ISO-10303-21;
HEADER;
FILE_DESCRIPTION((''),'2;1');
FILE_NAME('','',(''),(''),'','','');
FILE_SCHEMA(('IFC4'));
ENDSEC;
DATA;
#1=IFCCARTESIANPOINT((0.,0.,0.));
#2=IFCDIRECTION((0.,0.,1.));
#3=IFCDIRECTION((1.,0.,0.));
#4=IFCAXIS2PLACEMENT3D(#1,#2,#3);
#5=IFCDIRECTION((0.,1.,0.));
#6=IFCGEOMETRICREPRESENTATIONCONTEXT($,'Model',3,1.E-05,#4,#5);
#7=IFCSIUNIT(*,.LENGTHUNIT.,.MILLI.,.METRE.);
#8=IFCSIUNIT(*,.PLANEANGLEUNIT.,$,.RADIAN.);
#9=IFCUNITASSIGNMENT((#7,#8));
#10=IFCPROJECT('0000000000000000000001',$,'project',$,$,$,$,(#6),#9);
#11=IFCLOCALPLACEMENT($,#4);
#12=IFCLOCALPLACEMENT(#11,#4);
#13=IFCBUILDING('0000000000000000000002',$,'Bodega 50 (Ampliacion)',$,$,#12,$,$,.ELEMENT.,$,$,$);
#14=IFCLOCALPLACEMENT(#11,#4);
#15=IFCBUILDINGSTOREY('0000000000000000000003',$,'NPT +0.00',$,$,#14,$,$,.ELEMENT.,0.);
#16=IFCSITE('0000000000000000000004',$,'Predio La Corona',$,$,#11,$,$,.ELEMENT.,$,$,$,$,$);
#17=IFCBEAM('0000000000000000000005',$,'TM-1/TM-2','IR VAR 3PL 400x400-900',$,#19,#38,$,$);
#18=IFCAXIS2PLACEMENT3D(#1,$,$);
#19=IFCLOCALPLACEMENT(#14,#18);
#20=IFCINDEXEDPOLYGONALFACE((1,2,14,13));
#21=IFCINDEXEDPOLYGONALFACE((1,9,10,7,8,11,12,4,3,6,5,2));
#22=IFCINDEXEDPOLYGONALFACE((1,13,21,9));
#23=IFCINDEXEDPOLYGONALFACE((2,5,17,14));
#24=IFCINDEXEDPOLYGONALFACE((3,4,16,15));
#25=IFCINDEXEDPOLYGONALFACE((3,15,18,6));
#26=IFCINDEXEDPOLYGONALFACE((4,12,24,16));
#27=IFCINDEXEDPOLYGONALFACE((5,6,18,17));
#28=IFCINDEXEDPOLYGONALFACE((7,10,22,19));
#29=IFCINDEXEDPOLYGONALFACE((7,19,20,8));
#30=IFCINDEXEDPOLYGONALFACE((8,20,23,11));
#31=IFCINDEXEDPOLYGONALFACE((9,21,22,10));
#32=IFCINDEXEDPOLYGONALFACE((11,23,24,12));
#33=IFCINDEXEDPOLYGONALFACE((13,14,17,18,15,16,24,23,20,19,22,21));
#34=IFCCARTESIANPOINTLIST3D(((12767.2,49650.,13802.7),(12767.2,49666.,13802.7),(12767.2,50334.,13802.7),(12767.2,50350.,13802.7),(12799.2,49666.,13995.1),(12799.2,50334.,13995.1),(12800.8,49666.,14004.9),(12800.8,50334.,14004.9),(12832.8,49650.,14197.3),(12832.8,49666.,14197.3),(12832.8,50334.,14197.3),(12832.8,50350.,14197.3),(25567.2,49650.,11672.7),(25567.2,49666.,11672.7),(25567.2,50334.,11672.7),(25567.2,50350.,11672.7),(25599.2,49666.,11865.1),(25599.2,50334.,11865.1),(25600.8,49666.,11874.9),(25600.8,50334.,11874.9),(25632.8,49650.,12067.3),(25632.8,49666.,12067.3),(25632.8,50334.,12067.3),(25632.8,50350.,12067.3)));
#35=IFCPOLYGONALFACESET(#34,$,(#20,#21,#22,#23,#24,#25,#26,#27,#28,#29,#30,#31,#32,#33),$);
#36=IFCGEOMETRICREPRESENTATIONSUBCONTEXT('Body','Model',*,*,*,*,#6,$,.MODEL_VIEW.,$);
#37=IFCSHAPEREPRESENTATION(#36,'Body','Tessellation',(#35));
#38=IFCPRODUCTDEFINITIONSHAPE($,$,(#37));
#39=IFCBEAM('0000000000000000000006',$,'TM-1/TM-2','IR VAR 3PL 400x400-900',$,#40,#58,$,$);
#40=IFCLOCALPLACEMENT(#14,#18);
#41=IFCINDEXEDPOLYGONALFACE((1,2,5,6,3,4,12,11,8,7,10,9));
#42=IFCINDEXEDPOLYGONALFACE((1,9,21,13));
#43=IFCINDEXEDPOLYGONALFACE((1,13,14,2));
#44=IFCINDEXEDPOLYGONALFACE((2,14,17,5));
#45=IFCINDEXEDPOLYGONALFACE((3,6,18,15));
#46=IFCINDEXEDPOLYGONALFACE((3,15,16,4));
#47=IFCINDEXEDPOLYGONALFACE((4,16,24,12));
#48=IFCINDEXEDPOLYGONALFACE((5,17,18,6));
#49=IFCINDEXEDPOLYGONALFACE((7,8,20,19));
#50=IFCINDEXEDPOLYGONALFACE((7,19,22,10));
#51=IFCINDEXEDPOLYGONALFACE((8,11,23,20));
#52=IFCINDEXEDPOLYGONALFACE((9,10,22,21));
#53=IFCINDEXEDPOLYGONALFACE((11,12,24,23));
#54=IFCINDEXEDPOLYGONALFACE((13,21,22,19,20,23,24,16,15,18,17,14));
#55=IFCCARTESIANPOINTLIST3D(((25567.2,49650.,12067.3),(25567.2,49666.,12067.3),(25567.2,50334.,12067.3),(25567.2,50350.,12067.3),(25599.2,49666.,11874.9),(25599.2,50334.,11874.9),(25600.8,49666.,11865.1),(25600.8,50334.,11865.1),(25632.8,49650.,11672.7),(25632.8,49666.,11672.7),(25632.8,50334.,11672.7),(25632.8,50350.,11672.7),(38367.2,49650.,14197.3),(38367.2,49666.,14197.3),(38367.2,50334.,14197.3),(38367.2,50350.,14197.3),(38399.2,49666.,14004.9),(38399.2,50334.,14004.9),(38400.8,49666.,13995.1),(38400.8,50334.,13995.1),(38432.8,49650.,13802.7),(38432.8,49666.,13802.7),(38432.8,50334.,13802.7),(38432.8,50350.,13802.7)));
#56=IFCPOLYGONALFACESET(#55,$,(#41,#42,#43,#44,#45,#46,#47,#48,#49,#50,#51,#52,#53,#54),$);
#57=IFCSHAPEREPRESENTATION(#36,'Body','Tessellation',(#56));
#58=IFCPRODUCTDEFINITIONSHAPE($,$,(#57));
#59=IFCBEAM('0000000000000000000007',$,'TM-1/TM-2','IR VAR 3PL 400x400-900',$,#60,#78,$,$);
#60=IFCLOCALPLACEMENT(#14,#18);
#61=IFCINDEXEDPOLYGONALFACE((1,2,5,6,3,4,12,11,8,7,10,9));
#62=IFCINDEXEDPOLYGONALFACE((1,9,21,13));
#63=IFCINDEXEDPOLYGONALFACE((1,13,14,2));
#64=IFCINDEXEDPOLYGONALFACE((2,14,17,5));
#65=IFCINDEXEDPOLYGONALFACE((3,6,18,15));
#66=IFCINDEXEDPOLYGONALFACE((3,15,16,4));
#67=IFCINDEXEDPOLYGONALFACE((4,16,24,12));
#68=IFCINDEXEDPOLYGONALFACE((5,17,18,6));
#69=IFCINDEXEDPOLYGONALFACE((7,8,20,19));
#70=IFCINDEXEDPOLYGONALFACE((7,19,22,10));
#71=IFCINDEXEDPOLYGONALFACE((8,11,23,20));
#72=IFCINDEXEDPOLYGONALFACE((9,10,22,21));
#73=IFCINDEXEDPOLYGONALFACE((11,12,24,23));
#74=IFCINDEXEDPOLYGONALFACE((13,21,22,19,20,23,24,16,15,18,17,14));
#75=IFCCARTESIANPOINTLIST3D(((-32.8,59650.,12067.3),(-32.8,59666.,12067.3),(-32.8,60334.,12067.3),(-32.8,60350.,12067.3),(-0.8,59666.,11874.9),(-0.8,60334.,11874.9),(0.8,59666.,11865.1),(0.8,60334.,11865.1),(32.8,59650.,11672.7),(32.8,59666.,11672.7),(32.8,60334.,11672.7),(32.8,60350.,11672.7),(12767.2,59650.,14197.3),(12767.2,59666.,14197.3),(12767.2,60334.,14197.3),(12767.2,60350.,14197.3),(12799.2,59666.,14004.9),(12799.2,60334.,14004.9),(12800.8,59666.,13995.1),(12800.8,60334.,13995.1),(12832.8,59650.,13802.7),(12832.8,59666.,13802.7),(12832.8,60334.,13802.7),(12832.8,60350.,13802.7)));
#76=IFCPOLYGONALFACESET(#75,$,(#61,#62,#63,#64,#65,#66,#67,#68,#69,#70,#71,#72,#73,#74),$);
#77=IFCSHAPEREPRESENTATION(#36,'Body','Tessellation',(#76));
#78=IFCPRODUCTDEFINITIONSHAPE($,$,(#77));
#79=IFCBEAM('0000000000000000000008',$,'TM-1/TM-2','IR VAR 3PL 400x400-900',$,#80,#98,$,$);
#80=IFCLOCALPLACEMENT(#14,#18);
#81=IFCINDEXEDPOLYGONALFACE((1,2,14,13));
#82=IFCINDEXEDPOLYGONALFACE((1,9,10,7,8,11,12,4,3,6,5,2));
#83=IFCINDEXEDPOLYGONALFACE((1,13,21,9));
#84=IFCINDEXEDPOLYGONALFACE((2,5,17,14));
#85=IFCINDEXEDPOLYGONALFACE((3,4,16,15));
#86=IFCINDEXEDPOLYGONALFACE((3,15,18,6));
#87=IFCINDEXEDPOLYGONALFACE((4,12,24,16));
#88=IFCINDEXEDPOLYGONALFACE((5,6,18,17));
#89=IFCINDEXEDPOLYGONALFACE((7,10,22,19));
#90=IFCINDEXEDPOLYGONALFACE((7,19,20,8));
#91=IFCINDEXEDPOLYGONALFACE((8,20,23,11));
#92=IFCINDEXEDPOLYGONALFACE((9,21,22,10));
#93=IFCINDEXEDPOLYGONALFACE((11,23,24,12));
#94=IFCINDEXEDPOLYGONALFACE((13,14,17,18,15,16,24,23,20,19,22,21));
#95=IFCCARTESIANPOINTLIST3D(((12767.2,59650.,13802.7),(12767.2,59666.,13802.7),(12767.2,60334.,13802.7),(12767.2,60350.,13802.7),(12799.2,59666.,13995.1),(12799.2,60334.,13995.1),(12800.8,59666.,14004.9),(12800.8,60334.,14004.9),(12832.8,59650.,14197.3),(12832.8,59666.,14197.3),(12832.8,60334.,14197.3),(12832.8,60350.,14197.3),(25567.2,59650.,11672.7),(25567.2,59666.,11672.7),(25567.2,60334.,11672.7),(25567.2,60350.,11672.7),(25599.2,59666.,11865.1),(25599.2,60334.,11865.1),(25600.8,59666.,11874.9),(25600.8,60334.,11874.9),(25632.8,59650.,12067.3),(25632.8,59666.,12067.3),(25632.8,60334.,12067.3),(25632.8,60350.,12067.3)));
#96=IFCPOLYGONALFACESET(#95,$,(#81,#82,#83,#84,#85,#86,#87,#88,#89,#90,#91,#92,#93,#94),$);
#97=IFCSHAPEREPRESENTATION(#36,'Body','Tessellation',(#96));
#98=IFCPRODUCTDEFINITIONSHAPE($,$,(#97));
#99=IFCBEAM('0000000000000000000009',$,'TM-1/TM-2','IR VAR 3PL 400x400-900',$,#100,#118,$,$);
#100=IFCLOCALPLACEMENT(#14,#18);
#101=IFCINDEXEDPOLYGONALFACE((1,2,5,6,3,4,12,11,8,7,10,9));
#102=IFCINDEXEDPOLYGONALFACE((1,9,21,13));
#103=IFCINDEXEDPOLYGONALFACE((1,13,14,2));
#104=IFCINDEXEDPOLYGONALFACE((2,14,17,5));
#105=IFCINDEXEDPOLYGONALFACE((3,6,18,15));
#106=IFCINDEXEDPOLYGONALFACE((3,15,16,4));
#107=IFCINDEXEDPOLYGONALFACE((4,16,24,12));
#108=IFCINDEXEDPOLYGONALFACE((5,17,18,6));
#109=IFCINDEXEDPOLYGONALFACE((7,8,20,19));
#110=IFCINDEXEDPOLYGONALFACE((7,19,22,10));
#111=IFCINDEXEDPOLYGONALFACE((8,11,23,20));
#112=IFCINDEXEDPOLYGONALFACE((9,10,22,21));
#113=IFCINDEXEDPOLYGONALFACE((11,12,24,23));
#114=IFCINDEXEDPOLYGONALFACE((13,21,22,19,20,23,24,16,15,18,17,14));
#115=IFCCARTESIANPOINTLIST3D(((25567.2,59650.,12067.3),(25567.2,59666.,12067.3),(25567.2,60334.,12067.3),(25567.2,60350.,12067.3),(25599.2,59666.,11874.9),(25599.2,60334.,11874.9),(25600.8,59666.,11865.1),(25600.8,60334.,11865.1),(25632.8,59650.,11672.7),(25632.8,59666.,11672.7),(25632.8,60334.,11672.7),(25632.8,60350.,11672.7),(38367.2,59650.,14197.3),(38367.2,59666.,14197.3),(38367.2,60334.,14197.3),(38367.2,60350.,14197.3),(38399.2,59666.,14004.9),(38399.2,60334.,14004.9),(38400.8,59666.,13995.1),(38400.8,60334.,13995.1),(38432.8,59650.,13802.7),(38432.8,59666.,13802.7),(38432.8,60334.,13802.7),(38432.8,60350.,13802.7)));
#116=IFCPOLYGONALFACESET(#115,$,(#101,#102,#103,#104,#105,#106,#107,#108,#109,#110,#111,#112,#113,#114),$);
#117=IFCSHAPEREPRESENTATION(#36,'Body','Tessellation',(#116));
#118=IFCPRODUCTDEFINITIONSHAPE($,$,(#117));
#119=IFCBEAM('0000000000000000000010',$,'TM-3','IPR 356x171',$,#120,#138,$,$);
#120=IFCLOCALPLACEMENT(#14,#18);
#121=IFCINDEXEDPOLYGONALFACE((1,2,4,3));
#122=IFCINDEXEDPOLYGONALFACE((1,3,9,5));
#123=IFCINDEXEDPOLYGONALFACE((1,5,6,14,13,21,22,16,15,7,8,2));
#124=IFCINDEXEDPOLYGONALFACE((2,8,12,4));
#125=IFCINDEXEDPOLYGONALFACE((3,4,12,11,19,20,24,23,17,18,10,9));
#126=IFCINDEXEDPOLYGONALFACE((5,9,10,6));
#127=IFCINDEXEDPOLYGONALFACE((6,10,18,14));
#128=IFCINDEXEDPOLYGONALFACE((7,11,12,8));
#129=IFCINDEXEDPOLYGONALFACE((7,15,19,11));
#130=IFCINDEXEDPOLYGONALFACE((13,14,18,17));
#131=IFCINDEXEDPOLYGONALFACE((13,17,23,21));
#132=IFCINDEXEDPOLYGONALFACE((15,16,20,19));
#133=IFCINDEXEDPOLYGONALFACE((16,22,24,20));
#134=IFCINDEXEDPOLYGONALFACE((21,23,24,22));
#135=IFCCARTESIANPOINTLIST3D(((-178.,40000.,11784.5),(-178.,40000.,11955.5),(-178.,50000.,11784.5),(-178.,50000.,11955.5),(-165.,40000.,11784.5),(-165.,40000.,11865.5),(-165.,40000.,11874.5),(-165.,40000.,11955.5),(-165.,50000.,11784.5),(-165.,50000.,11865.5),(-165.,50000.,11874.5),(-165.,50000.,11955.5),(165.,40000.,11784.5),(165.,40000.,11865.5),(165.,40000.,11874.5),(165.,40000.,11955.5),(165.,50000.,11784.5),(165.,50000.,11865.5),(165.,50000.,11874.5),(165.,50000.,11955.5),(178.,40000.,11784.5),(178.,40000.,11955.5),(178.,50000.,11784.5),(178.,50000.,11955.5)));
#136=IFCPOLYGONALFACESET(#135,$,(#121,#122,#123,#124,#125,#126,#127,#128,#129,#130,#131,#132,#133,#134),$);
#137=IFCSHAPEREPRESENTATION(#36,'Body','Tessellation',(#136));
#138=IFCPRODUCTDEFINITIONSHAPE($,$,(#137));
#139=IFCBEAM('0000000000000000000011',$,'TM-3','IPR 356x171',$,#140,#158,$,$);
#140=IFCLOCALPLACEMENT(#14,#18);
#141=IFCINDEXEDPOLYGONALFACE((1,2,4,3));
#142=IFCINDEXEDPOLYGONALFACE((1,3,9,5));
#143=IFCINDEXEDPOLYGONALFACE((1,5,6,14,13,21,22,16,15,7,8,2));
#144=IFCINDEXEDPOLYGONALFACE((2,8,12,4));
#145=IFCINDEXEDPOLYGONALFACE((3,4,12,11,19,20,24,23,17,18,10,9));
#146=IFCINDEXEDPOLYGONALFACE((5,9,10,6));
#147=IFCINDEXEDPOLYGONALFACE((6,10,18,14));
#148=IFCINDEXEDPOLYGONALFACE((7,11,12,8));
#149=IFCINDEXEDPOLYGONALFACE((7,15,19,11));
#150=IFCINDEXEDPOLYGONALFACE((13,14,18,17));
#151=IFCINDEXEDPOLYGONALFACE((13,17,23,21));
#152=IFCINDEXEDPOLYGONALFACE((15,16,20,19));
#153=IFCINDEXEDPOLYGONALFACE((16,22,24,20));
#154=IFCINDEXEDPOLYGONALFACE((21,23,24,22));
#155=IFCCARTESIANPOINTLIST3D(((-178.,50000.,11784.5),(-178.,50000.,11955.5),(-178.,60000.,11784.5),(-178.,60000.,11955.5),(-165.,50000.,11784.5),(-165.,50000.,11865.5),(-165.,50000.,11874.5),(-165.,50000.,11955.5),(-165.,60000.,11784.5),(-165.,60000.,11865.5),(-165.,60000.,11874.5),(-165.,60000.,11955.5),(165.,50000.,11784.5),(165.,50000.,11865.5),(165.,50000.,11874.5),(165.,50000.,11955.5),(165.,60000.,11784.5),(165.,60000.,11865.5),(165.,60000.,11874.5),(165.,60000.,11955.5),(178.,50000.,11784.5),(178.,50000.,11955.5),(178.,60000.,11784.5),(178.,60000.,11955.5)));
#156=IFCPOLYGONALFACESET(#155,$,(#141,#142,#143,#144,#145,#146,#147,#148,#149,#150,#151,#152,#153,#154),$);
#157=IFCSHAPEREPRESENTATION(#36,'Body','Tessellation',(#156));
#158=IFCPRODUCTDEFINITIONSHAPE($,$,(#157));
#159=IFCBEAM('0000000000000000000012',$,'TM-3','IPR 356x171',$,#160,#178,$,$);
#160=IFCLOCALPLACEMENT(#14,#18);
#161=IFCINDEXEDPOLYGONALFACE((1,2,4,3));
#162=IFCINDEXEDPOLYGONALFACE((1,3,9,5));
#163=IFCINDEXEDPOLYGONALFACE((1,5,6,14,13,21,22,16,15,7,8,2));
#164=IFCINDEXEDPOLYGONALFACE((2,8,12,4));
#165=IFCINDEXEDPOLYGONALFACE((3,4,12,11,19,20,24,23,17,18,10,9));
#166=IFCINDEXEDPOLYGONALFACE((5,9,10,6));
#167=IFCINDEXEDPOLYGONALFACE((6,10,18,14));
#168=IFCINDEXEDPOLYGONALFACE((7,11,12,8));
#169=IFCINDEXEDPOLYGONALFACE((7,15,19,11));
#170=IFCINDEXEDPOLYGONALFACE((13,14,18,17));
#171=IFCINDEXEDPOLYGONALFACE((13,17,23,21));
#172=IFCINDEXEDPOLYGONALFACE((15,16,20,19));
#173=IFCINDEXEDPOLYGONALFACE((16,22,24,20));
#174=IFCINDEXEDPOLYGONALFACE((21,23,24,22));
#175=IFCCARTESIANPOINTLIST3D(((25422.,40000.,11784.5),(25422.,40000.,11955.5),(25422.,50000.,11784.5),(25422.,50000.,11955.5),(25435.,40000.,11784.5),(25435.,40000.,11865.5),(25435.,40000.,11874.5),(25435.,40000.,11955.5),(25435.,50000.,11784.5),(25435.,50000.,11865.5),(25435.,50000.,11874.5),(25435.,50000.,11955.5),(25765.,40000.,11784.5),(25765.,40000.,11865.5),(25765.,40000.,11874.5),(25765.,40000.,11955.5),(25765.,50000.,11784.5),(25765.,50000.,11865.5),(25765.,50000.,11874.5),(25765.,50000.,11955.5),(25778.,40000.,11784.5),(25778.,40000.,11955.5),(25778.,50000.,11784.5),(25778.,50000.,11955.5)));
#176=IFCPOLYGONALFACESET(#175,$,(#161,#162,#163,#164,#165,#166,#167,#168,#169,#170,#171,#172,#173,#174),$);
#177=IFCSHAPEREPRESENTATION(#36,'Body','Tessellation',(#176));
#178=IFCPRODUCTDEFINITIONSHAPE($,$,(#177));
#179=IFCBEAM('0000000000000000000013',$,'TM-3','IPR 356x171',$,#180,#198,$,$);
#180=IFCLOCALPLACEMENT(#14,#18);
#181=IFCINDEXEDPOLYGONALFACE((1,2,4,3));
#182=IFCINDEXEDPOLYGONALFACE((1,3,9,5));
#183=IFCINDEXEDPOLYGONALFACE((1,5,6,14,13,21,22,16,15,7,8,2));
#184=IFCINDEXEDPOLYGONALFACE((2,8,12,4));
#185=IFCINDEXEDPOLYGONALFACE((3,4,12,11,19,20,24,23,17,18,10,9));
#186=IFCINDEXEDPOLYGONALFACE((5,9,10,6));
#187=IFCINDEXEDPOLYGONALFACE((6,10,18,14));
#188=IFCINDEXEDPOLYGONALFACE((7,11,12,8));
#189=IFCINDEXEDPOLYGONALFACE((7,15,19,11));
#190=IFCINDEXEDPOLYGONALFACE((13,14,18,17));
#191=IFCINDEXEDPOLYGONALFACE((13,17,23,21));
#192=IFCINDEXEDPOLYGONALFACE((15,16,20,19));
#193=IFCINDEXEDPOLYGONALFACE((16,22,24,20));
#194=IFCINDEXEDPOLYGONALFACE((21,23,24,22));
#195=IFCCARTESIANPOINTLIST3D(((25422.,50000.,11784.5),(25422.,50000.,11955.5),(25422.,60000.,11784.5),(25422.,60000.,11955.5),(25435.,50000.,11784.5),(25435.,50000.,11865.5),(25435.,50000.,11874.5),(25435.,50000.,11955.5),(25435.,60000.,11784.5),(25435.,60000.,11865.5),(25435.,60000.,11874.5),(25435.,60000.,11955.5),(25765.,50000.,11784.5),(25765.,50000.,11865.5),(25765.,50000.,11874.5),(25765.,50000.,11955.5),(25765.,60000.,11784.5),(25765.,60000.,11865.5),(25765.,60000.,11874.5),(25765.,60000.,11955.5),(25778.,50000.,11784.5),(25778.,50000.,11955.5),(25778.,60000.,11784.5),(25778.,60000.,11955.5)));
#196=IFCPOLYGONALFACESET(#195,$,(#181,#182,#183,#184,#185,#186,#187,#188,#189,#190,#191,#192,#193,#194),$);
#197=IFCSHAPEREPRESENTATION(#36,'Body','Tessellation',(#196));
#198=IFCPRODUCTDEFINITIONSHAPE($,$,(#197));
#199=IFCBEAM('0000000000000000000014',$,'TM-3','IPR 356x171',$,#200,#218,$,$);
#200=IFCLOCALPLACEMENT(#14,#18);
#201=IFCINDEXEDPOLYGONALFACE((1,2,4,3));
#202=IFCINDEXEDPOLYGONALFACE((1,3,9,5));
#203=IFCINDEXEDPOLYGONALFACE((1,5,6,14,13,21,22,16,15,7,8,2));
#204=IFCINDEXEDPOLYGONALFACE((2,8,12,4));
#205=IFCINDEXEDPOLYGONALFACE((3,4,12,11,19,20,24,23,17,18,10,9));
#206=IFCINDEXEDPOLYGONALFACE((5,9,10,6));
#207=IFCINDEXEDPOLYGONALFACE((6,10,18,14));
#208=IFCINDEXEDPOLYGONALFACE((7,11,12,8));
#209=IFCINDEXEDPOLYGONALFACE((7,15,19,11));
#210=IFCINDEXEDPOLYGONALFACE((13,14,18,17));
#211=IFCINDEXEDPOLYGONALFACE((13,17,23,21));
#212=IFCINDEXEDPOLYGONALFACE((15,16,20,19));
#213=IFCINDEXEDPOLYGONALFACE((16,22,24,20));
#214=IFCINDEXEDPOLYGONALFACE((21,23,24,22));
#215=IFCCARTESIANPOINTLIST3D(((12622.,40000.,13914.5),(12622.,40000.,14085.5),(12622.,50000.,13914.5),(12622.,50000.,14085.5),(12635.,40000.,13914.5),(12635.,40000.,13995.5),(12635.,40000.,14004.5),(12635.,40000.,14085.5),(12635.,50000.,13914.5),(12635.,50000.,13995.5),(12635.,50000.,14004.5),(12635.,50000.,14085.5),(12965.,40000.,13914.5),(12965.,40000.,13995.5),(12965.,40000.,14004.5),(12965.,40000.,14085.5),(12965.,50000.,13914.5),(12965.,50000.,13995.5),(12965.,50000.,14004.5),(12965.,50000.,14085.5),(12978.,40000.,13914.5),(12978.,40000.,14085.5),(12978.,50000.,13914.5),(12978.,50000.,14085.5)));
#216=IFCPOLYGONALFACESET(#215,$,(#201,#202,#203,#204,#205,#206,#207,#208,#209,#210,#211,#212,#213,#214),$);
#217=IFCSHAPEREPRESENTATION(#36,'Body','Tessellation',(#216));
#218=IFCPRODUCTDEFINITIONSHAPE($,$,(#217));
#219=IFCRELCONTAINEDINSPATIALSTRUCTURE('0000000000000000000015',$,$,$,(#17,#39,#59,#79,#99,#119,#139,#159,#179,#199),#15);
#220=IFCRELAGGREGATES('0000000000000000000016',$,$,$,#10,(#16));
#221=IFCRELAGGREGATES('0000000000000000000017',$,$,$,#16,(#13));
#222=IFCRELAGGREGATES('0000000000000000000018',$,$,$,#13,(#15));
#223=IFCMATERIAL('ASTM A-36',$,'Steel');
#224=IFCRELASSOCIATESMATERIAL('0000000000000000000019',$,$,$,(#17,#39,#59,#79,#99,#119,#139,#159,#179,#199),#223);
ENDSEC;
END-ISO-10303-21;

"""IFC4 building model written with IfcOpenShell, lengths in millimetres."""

from ifc_helpers import new_model, si_unit, direction, frame, origin_with_axes, origin_2d, place, context, subcontext, project, spatial, i_section, extrude, material, element, save


model = new_model("IFC4")

# Units and contexts
model_context = context("Model", 3, precision=1e-05, world=origin_with_axes(), true_north=direction((0.0, 1.0, 0.0)))
body_context = subcontext(model_context, "Body", "Model", "MODEL_VIEW")
ifc_project = project(units=[si_unit("LENGTHUNIT", "METRE", prefix="MILLI"), si_unit("PLANEANGLEUNIT", "RADIAN")], contexts=[model_context])

# Site, building, storey
site_placement = place(None, origin_with_axes())
site = spatial("IfcSite", under=ifc_project, at=site_placement, Name="Predio La Corona", CompositionType="ELEMENT")
building_placement = place(site_placement, origin_with_axes())
building = spatial("IfcBuilding", under=site, at=building_placement, Name="Bodega 50 (Ampliacion)", CompositionType="ELEMENT")
storey_placement = place(site_placement, origin_with_axes())
storey = spatial("IfcBuildingStorey", under=building, at=storey_placement, Name="NPT +0.00", CompositionType="ELEMENT", Elevation=0.0)

# Shared definitions
ifc_material = material(Name="ASTM A-36", Category="Steel")

# Beams
for number, where, z_axis, x_axis, name in (
    (1, (12800.0, 50000.0, 14000.0), (0.986436, 0.0, -0.164149), (-0.164149, 0.0, -0.986436), "TM-1/TM-2"),
    (2, (25600.0, 50000.0, 11870.0), (0.986436, 0.0, 0.164149), (0.164149, 0.0, -0.986436), "TM-1/TM-2"),
    (3, (0.0, 60000.0, 11870.0), (0.986436, 0.0, 0.164149), (0.164149, 0.0, -0.986436), "TM-1/TM-2"),
    (4, (12800.0, 60000.0, 14000.0), (0.986436, 0.0, -0.164149), (-0.164149, 0.0, -0.986436), "TM-1/TM-2"),
    (5, (25600.0, 60000.0, 11870.0), (0.986436, 0.0, 0.164149), (0.164149, 0.0, -0.986436), "TM-1/TM-2"),
):
    element("IfcBeam", number, at=place(storey_placement, frame(where, z_axis=z_axis, x_axis=x_axis)), inside=storey, material=ifc_material, Name=name, Description="IR VAR 3PL 400x400-900", context=body_context, shape_type="SweptSolid", body=[
        extrude(i_section(OverallWidth=400.0, OverallDepth=700.0, WebThickness=10.0, FlangeThickness=16.0, at=origin_2d()), origin_with_axes(), (0.0, 0.0, 1.0), 12976.0),
    ])
for number, where, z_axis, x_axis, name in (
    (6, (0.0, 40000.0, 11870.0), (0.0, 1.0, 0.0), (0.0, 0.0, 1.0), "TM-3"),
    (7, (0.0, 50000.0, 11870.0), (0.0, 1.0, 0.0), (0.0, 0.0, 1.0), "TM-3"),
    (8, (25600.0, 40000.0, 11870.0), (0.0, 1.0, 0.0), (0.0, 0.0, 1.0), "TM-3"),
    (9, (25600.0, 50000.0, 11870.0), (0.0, 1.0, 0.0), (0.0, 0.0, 1.0), "TM-3"),
    (10, (12800.0, 40000.0, 14000.0), (0.0, 1.0, 0.0), (0.0, 0.0, 1.0), "TM-3"),
):
    element("IfcBeam", number, at=place(storey_placement, frame(where, z_axis=z_axis, x_axis=x_axis)), inside=storey, material=ifc_material, Name=name, Description="IPR 356x171", context=body_context, shape_type="SweptSolid", body=[
        extrude(i_section(OverallWidth=171.0, OverallDepth=356.0, WebThickness=9.0, FlangeThickness=13.0, at=origin_2d()), origin_with_axes(), (0.0, 0.0, 1.0), 10000.0),
    ])

save(model, "model.ifc")
